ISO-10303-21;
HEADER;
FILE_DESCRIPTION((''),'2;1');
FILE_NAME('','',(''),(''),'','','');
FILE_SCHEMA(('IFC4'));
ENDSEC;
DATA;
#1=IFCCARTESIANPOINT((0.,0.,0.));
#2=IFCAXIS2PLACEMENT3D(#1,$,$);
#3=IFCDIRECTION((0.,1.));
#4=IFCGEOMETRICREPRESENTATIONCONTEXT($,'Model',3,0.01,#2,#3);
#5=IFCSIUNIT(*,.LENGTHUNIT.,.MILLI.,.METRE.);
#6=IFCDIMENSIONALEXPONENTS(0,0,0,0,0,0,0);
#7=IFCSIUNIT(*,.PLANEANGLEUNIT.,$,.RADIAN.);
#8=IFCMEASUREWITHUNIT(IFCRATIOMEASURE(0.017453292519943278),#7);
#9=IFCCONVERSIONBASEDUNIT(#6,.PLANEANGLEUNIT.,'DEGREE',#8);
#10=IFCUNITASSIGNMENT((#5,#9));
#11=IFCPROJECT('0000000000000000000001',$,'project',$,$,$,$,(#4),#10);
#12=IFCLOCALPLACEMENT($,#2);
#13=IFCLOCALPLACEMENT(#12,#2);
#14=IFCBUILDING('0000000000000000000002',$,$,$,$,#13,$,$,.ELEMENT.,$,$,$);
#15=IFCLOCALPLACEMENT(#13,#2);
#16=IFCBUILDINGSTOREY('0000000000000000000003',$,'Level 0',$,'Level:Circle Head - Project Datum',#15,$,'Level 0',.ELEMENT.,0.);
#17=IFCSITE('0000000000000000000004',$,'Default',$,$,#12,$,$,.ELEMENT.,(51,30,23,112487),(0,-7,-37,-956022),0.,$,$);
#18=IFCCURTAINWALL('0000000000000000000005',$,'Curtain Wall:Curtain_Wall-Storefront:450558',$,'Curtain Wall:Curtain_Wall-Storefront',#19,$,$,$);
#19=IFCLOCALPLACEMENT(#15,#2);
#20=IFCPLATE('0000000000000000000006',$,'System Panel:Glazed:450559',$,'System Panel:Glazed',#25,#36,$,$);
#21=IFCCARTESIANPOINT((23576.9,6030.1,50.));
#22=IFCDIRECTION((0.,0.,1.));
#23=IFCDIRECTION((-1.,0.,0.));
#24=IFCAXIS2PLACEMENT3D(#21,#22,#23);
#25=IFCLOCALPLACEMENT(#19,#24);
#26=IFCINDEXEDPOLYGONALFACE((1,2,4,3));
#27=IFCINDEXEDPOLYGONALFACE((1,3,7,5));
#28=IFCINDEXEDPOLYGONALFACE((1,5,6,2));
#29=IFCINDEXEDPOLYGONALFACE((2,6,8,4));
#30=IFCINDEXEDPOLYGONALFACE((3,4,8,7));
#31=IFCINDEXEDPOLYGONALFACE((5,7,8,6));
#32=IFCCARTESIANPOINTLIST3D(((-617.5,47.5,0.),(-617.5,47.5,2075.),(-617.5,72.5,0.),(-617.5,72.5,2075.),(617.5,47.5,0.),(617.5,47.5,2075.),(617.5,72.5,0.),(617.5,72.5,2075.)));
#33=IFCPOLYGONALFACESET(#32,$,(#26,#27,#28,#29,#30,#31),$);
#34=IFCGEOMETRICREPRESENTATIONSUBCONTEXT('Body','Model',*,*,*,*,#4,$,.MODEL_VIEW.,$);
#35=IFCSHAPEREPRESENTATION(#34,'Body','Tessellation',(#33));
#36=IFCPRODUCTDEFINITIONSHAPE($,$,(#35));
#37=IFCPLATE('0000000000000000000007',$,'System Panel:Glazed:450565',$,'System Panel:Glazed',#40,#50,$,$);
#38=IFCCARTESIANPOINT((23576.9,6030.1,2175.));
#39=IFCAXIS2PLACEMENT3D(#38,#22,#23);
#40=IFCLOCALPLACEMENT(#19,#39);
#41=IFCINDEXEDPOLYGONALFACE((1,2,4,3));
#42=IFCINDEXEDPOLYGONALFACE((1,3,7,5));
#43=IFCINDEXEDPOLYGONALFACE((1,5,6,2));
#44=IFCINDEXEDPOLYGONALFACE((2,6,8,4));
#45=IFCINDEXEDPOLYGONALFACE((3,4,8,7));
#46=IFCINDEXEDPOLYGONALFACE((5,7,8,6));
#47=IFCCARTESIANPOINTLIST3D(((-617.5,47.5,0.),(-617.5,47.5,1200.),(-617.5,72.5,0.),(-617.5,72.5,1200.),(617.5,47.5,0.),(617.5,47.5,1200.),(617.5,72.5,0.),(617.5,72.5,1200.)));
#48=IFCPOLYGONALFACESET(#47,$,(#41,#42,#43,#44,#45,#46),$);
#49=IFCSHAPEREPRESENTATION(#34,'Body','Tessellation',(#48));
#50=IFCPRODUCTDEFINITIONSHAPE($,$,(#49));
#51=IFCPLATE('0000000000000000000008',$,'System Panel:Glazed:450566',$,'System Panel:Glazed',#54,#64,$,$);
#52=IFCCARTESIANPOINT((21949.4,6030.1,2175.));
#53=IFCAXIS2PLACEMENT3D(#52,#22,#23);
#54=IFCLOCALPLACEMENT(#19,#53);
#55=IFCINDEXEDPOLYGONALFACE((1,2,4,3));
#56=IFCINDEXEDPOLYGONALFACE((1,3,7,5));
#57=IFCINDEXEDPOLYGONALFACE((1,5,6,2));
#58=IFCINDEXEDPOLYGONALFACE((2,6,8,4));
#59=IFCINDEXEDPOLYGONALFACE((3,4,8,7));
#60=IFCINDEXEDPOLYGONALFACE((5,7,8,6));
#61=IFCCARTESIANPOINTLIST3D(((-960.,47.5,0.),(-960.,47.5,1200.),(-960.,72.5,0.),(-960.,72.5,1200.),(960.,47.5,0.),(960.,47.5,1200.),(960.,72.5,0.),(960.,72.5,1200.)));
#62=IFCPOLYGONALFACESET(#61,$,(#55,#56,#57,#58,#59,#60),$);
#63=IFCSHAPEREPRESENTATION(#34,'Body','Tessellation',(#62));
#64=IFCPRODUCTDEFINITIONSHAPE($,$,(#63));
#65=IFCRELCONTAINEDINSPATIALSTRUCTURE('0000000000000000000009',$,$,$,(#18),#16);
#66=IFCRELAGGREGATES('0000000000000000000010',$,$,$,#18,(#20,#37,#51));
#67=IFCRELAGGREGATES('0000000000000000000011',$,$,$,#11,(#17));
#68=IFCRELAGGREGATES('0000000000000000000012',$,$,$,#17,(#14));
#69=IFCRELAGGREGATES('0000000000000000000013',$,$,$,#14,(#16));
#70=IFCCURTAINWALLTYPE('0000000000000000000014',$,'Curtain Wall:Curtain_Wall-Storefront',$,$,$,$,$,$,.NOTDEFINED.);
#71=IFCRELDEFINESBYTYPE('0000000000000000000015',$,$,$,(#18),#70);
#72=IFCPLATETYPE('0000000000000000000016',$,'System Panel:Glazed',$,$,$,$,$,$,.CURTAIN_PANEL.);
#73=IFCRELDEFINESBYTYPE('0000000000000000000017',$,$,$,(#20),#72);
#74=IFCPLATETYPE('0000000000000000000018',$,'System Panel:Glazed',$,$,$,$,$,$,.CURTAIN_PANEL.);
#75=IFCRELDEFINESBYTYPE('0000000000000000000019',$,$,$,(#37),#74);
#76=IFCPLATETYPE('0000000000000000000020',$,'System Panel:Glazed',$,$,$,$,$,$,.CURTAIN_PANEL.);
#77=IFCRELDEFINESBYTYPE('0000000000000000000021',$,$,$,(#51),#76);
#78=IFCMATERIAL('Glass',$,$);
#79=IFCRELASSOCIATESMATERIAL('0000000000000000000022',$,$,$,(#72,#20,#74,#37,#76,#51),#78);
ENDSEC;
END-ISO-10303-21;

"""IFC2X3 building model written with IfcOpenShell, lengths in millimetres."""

from ifc_helpers import new_model, entity, si_unit, converted_unit, direction, frame, origin, origin_2d_with_axis, place, context, subcontext, project, spatial, rectangle, extrude, source, transform, mapped, material, type_object, type_shapes, element, aggregate, save


model = new_model("IFC2X3")

# Units and contexts
model_context = context("Model", 3, precision=0.01, world=origin(), true_north=direction((0.0, 1.0)))
body_context = subcontext(model_context, "Body", "Model", "MODEL_VIEW")
ifc_project = project(units=[si_unit("LENGTHUNIT", "METRE", prefix="MILLI"), converted_unit("PLANEANGLEUNIT", "DEGREE", entity("IfcRatioMeasure", 0.017453292519943278), si_unit("PLANEANGLEUNIT", "RADIAN"), dimensions=[0, 0, 0, 0, 0, 0, 0])], contexts=[model_context])

# Site, building, storey
site_placement = place(None, origin())
site = spatial("IfcSite", under=ifc_project, at=site_placement, Name="Default", CompositionType="ELEMENT", RefLatitude=(51, 30, 23, 112487), RefLongitude=(0, -7, -37, -956022), RefElevation=0.0)
building_placement = place(site_placement, origin())
building = spatial("IfcBuilding", under=site, at=building_placement, CompositionType="ELEMENT")
storey_placement = place(building_placement, origin())
storey = spatial("IfcBuildingStorey", under=building, at=storey_placement, Name="Level 0", ObjectType="Level:Circle Head - Project Datum", LongName="Level 0", CompositionType="ELEMENT", Elevation=0.0)

# Curtain wall, plates
curtain_wall_type = type_object("IfcCurtainWallType", Name="Curtain Wall:Curtain_Wall-Storefront", PredefinedType="NOTDEFINED")
curtain_wall_placement = place(storey_placement, origin())
curtain_wall = element("IfcCurtainWall", 1, at=curtain_wall_placement, inside=storey, type_object=curtain_wall_type, Name="Curtain Wall:Curtain_Wall-Storefront:450558", ObjectType="Curtain Wall:Curtain_Wall-Storefront")
ifc_material_1 = material(Name="Glass")
plate_type_1 = type_object("IfcPlateType", Name="System Panel:Glazed", PredefinedType="CURTAIN_PANEL", material=ifc_material_1)
shared_shape_1 = source(origin(), body_context, "Body", "SweptSolid", [
    extrude(rectangle(XDim=25.0, YDim=1235.0, at=origin_2d_with_axis()), frame((0.0, 60.0, 0.0), z_axis=(0.0, 0.0, 1.0), x_axis=(0.0, 1.0, 0.0)), (0.0, 0.0, 1.0), 2075.0),
])
type_shapes(plate_type_1, [shared_shape_1])
plate_1_placement = place(curtain_wall_placement, frame((23576.9, 6030.1, 50.0), z_axis=(0.0, 0.0, 1.0), x_axis=(-1.0, 0.0, 0.0)))
plate_1 = element("IfcPlate", 2, at=plate_1_placement, type_object=plate_type_1, material=ifc_material_1, Name="System Panel:Glazed:450559", ObjectType="System Panel:Glazed", context=body_context, shape_type="MappedRepresentation", body=[
    mapped(shared_shape_1, transform((0.0, 0.0, 0.0), scale=1.0)),
])
plate_type_2 = type_object("IfcPlateType", Name="System Panel:Glazed", PredefinedType="CURTAIN_PANEL", material=ifc_material_1)
shared_shape_2 = source(origin(), body_context, "Body", "SweptSolid", [
    extrude(rectangle(XDim=25.0, YDim=1235.0, at=origin_2d_with_axis()), frame((0.0, 60.0, 0.0), z_axis=(0.0, 0.0, 1.0), x_axis=(0.0, 1.0, 0.0)), (0.0, 0.0, 1.0), 1200.0),
])
type_shapes(plate_type_2, [shared_shape_2])
plate_2_placement = place(curtain_wall_placement, frame((23576.9, 6030.1, 2175.0), z_axis=(0.0, 0.0, 1.0), x_axis=(-1.0, 0.0, 0.0)))
plate_2 = element("IfcPlate", 3, at=plate_2_placement, type_object=plate_type_2, material=ifc_material_1, Name="System Panel:Glazed:450565", ObjectType="System Panel:Glazed", context=body_context, shape_type="MappedRepresentation", body=[
    mapped(shared_shape_2, transform((0.0, 0.0, 0.0), scale=1.0)),
])
plate_type_3 = type_object("IfcPlateType", Name="System Panel:Glazed", PredefinedType="CURTAIN_PANEL", material=ifc_material_1)
shared_shape_3 = source(origin(), body_context, "Body", "SweptSolid", [
    extrude(rectangle(XDim=25.0, YDim=1920.0, at=origin_2d_with_axis()), frame((0.0, 60.0, 0.0), z_axis=(0.0, 0.0, 1.0), x_axis=(0.0, 1.0, 0.0)), (0.0, 0.0, 1.0), 1200.0),
])
type_shapes(plate_type_3, [shared_shape_3])
plate_3_placement = place(curtain_wall_placement, frame((21949.4, 6030.1, 2175.0), z_axis=(0.0, 0.0, 1.0), x_axis=(-1.0, 0.0, 0.0)))
plate_3 = element("IfcPlate", 4, at=plate_3_placement, type_object=plate_type_3, material=ifc_material_1, Name="System Panel:Glazed:450566", ObjectType="System Panel:Glazed", context=body_context, shape_type="MappedRepresentation", body=[
    mapped(shared_shape_3, transform((0.0, 0.0, 0.0), scale=1.0)),
])
aggregate(curtain_wall, [plate_1, plate_2, plate_3])

save(model, "model.ifc")
